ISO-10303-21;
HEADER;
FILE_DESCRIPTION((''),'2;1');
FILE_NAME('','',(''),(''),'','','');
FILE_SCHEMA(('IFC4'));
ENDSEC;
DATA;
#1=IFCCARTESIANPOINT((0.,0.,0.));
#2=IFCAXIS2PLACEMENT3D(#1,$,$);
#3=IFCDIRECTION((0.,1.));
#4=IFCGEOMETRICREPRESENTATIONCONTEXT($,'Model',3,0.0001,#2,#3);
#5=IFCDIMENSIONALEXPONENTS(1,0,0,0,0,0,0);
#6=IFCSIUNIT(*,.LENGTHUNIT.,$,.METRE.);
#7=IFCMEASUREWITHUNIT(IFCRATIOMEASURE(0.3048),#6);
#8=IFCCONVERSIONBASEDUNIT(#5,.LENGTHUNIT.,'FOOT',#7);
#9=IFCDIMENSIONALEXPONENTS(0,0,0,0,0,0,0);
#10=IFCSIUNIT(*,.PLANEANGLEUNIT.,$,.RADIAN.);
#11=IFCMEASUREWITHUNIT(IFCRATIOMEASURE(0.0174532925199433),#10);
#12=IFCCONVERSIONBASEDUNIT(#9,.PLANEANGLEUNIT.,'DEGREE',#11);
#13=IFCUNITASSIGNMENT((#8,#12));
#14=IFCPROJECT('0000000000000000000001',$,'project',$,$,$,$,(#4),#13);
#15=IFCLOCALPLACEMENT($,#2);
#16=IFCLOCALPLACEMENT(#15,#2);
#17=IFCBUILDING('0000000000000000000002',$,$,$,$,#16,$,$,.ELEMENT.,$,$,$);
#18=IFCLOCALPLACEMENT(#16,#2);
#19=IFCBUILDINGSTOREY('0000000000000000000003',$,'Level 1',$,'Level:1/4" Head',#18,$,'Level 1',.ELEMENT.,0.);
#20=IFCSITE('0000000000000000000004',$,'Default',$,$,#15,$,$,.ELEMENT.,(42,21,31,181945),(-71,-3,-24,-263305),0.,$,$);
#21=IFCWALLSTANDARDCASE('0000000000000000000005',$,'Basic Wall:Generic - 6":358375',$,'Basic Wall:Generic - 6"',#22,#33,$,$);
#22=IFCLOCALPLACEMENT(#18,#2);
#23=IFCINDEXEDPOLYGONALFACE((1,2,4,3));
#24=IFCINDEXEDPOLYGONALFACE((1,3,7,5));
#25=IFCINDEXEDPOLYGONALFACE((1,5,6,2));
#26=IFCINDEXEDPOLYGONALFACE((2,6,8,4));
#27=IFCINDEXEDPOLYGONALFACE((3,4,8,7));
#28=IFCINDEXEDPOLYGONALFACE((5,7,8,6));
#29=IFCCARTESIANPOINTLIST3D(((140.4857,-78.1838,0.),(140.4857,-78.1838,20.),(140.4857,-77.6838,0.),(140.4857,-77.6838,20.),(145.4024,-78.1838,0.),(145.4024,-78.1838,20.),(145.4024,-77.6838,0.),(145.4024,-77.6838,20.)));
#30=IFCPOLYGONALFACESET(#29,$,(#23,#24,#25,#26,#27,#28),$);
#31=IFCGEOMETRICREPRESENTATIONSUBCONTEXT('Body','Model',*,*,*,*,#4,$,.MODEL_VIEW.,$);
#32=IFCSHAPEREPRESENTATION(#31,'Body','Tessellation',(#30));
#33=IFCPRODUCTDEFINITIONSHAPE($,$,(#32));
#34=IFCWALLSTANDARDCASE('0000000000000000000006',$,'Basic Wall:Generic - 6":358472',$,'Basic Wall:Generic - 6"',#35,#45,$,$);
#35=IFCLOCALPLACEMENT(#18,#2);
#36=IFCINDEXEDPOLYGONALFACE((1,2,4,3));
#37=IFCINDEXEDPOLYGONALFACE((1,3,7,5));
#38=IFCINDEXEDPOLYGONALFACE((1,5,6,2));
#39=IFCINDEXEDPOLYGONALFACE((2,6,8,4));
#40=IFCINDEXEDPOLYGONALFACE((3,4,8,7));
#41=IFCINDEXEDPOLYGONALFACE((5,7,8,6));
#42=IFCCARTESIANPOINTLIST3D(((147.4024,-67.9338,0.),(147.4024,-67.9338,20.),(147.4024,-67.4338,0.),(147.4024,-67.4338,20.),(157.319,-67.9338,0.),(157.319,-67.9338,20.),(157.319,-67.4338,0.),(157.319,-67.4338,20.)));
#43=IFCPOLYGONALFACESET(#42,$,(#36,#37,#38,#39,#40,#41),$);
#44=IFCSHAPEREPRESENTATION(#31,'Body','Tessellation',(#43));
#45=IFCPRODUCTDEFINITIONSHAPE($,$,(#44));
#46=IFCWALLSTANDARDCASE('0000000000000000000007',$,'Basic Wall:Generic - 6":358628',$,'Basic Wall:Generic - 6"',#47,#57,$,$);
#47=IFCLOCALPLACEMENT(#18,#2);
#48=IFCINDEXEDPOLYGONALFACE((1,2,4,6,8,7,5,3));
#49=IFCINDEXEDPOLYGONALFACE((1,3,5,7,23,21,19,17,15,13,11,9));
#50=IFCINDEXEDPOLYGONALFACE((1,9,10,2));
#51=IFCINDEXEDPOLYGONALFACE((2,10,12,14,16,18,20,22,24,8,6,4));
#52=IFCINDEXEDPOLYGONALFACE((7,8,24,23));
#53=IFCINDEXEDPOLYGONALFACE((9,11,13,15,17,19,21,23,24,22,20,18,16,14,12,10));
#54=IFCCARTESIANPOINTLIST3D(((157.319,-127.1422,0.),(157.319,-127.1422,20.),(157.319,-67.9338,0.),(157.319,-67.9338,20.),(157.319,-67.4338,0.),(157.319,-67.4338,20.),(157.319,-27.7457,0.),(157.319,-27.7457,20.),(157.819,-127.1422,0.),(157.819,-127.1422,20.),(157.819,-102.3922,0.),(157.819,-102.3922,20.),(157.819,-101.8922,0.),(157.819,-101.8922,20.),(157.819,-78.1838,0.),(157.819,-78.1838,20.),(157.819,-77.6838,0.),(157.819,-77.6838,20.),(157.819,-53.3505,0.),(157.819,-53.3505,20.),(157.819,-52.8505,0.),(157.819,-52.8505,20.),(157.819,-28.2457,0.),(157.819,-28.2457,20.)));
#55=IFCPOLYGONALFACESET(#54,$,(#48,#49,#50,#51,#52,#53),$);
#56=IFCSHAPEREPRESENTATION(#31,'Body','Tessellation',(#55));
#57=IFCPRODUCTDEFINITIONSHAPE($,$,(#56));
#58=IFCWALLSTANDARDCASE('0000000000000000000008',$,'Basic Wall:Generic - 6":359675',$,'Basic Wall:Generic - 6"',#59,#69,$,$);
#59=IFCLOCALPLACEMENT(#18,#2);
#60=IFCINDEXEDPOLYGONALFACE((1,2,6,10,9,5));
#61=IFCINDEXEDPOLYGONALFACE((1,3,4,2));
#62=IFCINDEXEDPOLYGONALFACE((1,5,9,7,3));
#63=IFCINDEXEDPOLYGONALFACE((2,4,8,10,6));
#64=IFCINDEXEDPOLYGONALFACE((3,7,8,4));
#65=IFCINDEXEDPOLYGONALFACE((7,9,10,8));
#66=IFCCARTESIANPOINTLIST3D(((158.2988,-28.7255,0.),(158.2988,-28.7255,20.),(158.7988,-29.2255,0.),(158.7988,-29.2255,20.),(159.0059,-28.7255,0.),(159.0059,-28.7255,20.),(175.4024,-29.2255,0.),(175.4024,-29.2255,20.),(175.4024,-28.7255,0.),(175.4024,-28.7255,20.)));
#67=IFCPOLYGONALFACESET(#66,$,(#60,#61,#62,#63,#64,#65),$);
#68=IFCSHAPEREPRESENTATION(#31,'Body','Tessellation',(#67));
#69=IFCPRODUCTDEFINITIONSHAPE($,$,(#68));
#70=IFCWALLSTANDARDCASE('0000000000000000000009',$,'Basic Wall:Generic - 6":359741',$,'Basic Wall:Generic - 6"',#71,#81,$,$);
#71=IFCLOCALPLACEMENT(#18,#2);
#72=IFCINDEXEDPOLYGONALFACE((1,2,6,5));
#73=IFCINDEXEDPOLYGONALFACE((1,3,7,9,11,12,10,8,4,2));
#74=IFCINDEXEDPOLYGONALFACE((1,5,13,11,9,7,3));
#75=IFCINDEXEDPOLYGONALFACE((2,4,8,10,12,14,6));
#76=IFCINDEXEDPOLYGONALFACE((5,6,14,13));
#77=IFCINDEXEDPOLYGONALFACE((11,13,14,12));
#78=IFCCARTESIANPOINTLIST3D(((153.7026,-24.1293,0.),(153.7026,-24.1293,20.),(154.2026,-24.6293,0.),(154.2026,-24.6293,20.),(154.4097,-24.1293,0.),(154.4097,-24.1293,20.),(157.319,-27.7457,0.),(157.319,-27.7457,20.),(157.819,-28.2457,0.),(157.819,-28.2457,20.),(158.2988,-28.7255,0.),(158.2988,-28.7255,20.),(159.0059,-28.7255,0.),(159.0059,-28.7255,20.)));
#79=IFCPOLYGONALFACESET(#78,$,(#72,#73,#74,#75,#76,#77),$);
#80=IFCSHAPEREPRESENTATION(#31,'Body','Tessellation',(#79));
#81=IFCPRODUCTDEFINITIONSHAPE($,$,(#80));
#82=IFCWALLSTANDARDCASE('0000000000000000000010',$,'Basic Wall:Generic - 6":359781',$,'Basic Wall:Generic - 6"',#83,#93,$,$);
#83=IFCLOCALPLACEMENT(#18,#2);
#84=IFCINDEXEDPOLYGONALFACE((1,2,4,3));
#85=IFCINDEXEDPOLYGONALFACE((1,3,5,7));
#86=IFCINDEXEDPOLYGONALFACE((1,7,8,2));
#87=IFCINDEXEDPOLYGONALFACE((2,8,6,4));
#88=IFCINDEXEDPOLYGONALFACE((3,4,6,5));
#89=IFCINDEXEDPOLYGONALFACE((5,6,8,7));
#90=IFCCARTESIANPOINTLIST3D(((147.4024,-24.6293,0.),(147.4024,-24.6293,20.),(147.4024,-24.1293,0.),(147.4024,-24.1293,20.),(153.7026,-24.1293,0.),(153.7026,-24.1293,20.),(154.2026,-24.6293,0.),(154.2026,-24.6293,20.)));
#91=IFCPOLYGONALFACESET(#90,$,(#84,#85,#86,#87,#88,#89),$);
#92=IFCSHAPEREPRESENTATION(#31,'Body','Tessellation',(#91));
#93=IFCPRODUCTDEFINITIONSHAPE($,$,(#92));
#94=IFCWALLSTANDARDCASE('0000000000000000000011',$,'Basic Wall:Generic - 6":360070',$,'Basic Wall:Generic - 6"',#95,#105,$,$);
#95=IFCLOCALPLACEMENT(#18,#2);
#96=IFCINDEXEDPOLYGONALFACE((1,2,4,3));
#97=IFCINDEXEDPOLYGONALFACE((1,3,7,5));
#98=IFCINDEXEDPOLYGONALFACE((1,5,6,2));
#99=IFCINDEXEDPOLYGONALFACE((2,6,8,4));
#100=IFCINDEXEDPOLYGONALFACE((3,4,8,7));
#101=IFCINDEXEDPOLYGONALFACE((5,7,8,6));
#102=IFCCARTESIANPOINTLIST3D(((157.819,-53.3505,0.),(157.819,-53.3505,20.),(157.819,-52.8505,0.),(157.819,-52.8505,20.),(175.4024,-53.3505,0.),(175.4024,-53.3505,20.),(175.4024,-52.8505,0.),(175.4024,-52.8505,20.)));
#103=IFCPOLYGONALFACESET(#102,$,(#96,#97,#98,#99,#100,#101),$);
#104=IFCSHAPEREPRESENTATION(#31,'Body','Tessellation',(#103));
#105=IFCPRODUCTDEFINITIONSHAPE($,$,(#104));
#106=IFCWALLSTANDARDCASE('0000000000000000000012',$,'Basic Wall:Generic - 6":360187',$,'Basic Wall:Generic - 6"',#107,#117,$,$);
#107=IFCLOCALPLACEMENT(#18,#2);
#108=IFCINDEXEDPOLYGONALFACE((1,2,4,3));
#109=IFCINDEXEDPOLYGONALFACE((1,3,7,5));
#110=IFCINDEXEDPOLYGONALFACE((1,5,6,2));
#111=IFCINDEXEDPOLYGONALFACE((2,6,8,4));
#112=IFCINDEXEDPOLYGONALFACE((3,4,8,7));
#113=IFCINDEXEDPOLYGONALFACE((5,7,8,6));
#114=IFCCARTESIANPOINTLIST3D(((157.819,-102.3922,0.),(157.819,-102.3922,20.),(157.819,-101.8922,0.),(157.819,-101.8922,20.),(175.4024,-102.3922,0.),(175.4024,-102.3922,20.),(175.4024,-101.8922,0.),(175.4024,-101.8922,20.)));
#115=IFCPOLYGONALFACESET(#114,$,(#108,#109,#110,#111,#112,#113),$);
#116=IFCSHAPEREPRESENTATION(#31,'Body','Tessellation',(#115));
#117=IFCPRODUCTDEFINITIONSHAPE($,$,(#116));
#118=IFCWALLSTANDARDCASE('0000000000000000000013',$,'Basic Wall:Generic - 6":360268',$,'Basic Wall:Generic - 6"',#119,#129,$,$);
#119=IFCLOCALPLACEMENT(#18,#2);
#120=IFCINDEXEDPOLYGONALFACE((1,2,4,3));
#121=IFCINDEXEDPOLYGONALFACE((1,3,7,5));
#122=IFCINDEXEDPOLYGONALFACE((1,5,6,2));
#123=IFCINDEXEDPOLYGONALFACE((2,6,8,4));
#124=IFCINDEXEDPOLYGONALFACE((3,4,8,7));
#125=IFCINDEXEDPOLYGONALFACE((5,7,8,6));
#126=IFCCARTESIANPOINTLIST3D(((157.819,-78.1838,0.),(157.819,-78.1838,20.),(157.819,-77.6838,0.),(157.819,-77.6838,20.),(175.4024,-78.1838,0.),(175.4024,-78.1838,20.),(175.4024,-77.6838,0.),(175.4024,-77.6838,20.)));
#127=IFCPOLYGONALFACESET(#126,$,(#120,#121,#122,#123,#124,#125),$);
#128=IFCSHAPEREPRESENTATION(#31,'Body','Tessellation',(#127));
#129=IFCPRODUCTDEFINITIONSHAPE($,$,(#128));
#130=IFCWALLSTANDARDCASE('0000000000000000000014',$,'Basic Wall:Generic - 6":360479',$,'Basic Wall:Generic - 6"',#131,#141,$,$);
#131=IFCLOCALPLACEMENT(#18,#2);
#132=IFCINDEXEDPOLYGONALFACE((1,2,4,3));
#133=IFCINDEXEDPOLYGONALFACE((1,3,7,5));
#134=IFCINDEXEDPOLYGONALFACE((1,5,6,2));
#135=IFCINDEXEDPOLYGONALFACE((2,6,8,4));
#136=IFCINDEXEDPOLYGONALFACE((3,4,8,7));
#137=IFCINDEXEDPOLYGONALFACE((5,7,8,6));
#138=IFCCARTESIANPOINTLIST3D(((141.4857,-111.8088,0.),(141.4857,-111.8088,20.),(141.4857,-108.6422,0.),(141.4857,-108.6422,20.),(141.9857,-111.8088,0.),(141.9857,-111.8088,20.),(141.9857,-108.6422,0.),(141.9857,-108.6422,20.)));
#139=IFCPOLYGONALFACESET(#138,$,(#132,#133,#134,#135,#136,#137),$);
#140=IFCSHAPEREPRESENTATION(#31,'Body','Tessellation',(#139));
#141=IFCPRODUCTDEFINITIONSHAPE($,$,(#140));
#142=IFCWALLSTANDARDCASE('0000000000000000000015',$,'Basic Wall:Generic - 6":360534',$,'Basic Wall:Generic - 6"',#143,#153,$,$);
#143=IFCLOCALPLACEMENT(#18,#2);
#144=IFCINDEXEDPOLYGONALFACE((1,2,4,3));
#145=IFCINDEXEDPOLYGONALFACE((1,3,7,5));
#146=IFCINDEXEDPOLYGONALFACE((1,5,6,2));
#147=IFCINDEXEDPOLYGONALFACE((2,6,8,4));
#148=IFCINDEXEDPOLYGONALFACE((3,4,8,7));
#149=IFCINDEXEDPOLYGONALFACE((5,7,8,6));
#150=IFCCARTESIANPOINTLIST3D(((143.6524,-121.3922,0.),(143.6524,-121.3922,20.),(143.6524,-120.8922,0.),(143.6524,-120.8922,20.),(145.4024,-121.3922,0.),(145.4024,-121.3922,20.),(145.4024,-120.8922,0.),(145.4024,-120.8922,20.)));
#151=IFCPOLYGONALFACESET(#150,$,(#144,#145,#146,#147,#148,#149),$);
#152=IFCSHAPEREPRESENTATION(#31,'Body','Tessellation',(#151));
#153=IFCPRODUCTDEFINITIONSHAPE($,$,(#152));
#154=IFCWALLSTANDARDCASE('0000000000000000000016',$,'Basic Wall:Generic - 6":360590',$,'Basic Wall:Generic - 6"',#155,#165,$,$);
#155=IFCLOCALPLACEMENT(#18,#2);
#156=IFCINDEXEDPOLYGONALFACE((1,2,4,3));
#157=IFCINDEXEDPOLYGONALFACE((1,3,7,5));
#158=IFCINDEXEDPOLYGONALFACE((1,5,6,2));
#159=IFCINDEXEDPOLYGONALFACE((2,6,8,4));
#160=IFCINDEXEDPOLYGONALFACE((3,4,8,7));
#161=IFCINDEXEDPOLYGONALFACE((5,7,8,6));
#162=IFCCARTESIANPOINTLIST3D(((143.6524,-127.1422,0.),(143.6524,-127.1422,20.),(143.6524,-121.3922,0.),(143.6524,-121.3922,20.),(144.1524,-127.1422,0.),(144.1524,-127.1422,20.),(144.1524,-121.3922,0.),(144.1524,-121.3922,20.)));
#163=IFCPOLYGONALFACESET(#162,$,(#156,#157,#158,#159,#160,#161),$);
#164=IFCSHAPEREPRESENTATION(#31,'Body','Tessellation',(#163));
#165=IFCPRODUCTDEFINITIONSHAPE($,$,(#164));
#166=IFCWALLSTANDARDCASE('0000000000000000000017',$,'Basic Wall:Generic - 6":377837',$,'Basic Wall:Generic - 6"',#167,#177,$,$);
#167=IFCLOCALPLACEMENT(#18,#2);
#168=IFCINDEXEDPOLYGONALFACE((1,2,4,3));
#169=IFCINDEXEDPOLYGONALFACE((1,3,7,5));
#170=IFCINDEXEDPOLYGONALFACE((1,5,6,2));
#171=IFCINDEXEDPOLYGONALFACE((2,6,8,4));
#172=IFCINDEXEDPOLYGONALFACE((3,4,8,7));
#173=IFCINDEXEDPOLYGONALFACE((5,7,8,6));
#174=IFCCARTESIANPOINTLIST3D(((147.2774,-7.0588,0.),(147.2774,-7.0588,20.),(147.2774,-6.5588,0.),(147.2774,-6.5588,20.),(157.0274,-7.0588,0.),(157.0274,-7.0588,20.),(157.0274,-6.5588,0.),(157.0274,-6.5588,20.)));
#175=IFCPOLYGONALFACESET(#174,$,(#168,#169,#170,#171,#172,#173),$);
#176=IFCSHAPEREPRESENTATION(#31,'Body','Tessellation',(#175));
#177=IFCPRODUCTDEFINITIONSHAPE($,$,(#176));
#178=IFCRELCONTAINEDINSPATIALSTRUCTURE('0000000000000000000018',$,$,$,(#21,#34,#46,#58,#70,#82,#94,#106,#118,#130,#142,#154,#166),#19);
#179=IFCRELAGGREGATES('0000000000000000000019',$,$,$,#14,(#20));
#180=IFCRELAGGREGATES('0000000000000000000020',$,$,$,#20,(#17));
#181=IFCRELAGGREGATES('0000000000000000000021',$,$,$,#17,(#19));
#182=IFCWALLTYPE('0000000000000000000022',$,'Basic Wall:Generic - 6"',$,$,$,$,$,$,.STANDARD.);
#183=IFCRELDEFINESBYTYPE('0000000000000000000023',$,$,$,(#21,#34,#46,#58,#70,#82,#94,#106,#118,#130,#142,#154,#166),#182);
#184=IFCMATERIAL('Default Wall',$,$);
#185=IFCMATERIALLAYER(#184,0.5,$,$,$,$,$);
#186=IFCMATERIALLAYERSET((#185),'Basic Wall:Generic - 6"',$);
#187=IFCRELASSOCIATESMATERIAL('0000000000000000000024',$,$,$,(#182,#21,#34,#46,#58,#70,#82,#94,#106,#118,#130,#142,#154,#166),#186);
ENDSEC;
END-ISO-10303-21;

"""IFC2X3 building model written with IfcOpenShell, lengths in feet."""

from ifc_helpers import new_model, entity, si_unit, converted_unit, direction, frame, frame_2d, origin, place, context, subcontext, project, spatial, polyline, rectangle, outline, extrude, material, layer, layer_set, layer_usage, type_object, element, save


model = new_model("IFC2X3")

# Units and contexts
model_context = context("Model", 3, precision=0.0001, world=origin(), true_north=direction((0.0, 1.0)))
body_context = subcontext(model_context, "Body", "Model", "MODEL_VIEW")
ifc_project = project(units=[converted_unit("LENGTHUNIT", "FOOT", entity("IfcRatioMeasure", 0.3048), si_unit("LENGTHUNIT", "METRE"), dimensions=[1, 0, 0, 0, 0, 0, 0]), converted_unit("PLANEANGLEUNIT", "DEGREE", entity("IfcRatioMeasure", 0.0174532925199433), si_unit("PLANEANGLEUNIT", "RADIAN"), dimensions=[0, 0, 0, 0, 0, 0, 0])], contexts=[model_context])

# Site, building, storey
site_placement = place(None, origin())
site = spatial("IfcSite", under=ifc_project, at=site_placement, Name="Default", CompositionType="ELEMENT", RefLatitude=(42, 21, 31, 181945), RefLongitude=(-71, -3, -24, -263305), RefElevation=0.0)
building_placement = place(site_placement, origin())
building = spatial("IfcBuilding", under=site, at=building_placement, CompositionType="ELEMENT")
storey_placement = place(building_placement, origin())
storey = spatial("IfcBuildingStorey", under=building, at=storey_placement, Name="Level 1", ObjectType="Level:1/4\" Head", LongName="Level 1", CompositionType="ELEMENT", Elevation=0.0)

# Walls
ifc_material = material(Name="Default Wall")
ifc_layer_1 = layer(ifc_material, 0.5)
ifc_layer_set_1 = layer_set([ifc_layer_1], Name="Basic Wall:Generic - 6\"")
wall_type_1 = type_object("IfcWallType", Name="Basic Wall:Generic - 6\"", PredefinedType="STANDARD", material=ifc_layer_set_1)
ifc_layer_usage_1 = layer_usage(ifc_layer_set_1, "AXIS2", "NEGATIVE", 0.25)
wall_1_placement = place(storey_placement, frame((140.4857, -77.9338, 0.0)))
element("IfcWallStandardCase", 1, at=wall_1_placement, inside=storey, type_object=wall_type_1, material=ifc_layer_usage_1, Name="Basic Wall:Generic - 6\":358375", ObjectType="Basic Wall:Generic - 6\"", context=body_context, shape_type="SweptSolid", body=[
    extrude(rectangle(XDim=4.9167, YDim=0.5, at=frame_2d((2.4583, 0.0), x_axis=(-1.0, 0.0))), origin(), (0.0, 0.0, 1.0), 20.0),
])
ifc_layer_usage_2 = layer_usage(ifc_layer_set_1, "AXIS2", "NEGATIVE", 0.25)
wall_2_placement = place(storey_placement, frame((147.4024, -67.6838, 0.0)))
element("IfcWallStandardCase", 2, at=wall_2_placement, inside=storey, type_object=wall_type_1, material=ifc_layer_usage_2, Name="Basic Wall:Generic - 6\":358472", ObjectType="Basic Wall:Generic - 6\"", context=body_context, shape_type="SweptSolid", body=[
    extrude(rectangle(XDim=9.9167, YDim=0.5, at=frame_2d((4.9583, 0.0), x_axis=(-1.0, 0.0))), origin(), (0.0, 0.0, 1.0), 20.0),
])
ifc_layer_usage_3 = layer_usage(ifc_layer_set_1, "AXIS2", "NEGATIVE", 0.25)
wall_3_placement = place(storey_placement, frame((157.569, -27.7457, 0.0), z_axis=(0.0, 0.0, 1.0), x_axis=(0.0, -1.0, 0.0)))
element("IfcWallStandardCase", 3, at=wall_3_placement, inside=storey, type_object=wall_type_1, material=ifc_layer_usage_3, Name="Basic Wall:Generic - 6\":358628", ObjectType="Basic Wall:Generic - 6\"", context=body_context, shape_type="SweptSolid", body=[
    extrude(outline(polyline([(99.3964, -0.25), (99.3964, 0.25), (74.6464, 0.25), (74.1464, 0.25), (50.4381, 0.25), (49.9381, 0.25), (25.6048, 0.25), (25.1048, 0.25), (0.5, 0.25), (0.0, -0.25), (39.6881, -0.25), (40.1881, -0.25), (99.3964, -0.25)])), origin(), (0.0, 0.0, 1.0), 20.0),
])
ifc_layer_usage_4 = layer_usage(ifc_layer_set_1, "AXIS2", "NEGATIVE", 0.25)
wall_4_placement = place(storey_placement, frame((175.4024, -28.9755, 0.0), z_axis=(0.0, 0.0, 1.0), x_axis=(-1.0, 0.0, 0.0)))
element("IfcWallStandardCase", 4, at=wall_4_placement, inside=storey, type_object=wall_type_1, material=ifc_layer_usage_4, Name="Basic Wall:Generic - 6\":359675", ObjectType="Basic Wall:Generic - 6\"", context=body_context, shape_type="SweptSolid", body=[
    extrude(outline(polyline([(17.1036, -0.25), (16.6036, 0.25), (0.0, 0.25), (0.0, -0.25), (16.3964, -0.25), (17.1036, -0.25)])), origin(), (0.0, 0.0, 1.0), 20.0),
])
ifc_layer_usage_5 = layer_usage(ifc_layer_set_1, "AXIS2", "NEGATIVE", 0.25)
wall_5_placement = place(storey_placement, frame((158.8291, -28.9023, 0.0), z_axis=(0.0, 0.0, 1.0), x_axis=(-0.707107, 0.707107, 0.0)))
element("IfcWallStandardCase", 5, at=wall_5_placement, inside=storey, type_object=wall_type_1, material=ifc_layer_usage_5, Name="Basic Wall:Generic - 6\":359741", ObjectType="Basic Wall:Generic - 6\"", context=body_context, shape_type="SweptSolid", body=[
    extrude(outline(polyline([(6.5, -0.25), (7.0, 0.25), (6.2929, 0.25), (1.8856, 0.25), (1.1785, 0.25), (0.5, 0.25), (0.0, -0.25), (6.5, -0.25)])), origin(), (0.0, 0.0, 1.0), 20.0),
])
ifc_layer_usage_6 = layer_usage(ifc_layer_set_1, "AXIS2", "NEGATIVE", 0.25)
wall_6_placement = place(storey_placement, frame((154.2026, -24.3793, 0.0), z_axis=(0.0, 0.0, 1.0), x_axis=(-1.0, 0.0, 0.0)))
element("IfcWallStandardCase", 6, at=wall_6_placement, inside=storey, type_object=wall_type_1, material=ifc_layer_usage_6, Name="Basic Wall:Generic - 6\":359781", ObjectType="Basic Wall:Generic - 6\"", context=body_context, shape_type="SweptSolid", body=[
    extrude(outline(polyline([(6.8003, -0.25), (6.8003, 0.25), (0.0, 0.25), (0.5, -0.25), (6.8003, -0.25)])), origin(), (0.0, 0.0, 1.0), 20.0),
])
ifc_layer_usage_7 = layer_usage(ifc_layer_set_1, "AXIS2", "NEGATIVE", 0.25)
wall_7_placement = place(storey_placement, frame((157.819, -53.1005, 0.0)))
element("IfcWallStandardCase", 7, at=wall_7_placement, inside=storey, type_object=wall_type_1, material=ifc_layer_usage_7, Name="Basic Wall:Generic - 6\":360070", ObjectType="Basic Wall:Generic - 6\"", context=body_context, shape_type="SweptSolid", body=[
    extrude(rectangle(XDim=17.5833, YDim=0.5, at=frame_2d((8.7917, 0.0), x_axis=(-1.0, 0.0))), origin(), (0.0, 0.0, 1.0), 20.0),
])
ifc_layer_usage_8 = layer_usage(ifc_layer_set_1, "AXIS2", "NEGATIVE", 0.25)
wall_8_placement = place(storey_placement, frame((175.4024, -102.1422, 0.0), z_axis=(0.0, 0.0, 1.0), x_axis=(-1.0, 0.0, 0.0)))
element("IfcWallStandardCase", 8, at=wall_8_placement, inside=storey, type_object=wall_type_1, material=ifc_layer_usage_8, Name="Basic Wall:Generic - 6\":360187", ObjectType="Basic Wall:Generic - 6\"", context=body_context, shape_type="SweptSolid", body=[
    extrude(rectangle(XDim=17.5833, YDim=0.5, at=frame_2d((8.7917, 0.0), x_axis=(-1.0, 0.0))), origin(), (0.0, 0.0, 1.0), 20.0),
])
ifc_layer_usage_9 = layer_usage(ifc_layer_set_1, "AXIS2", "NEGATIVE", 0.25)
wall_9_placement = place(storey_placement, frame((175.4024, -77.9338, 0.0), z_axis=(0.0, 0.0, 1.0), x_axis=(-1.0, 0.0, 0.0)))
element("IfcWallStandardCase", 9, at=wall_9_placement, inside=storey, type_object=wall_type_1, material=ifc_layer_usage_9, Name="Basic Wall:Generic - 6\":360268", ObjectType="Basic Wall:Generic - 6\"", context=body_context, shape_type="SweptSolid", body=[
    extrude(rectangle(XDim=17.5833, YDim=0.5, at=frame_2d((8.7917, 0.0), x_axis=(-1.0, 0.0))), origin(), (0.0, 0.0, 1.0), 20.0),
])
ifc_layer_usage_10 = layer_usage(ifc_layer_set_1, "AXIS2", "NEGATIVE", 0.25)
wall_10_placement = place(storey_placement, frame((141.7357, -111.8088, 0.0), z_axis=(0.0, 0.0, 1.0), x_axis=(0.0, 1.0, 0.0)))
element("IfcWallStandardCase", 10, at=wall_10_placement, inside=storey, type_object=wall_type_1, material=ifc_layer_usage_10, Name="Basic Wall:Generic - 6\":360479", ObjectType="Basic Wall:Generic - 6\"", context=body_context, shape_type="SweptSolid", body=[
    extrude(rectangle(XDim=3.1667, YDim=0.5, at=frame_2d((1.5833, 0.0), x_axis=(-1.0, 0.0))), origin(), (0.0, 0.0, 1.0), 20.0),
])
ifc_layer_usage_11 = layer_usage(ifc_layer_set_1, "AXIS2", "NEGATIVE", 0.25)
wall_11_placement = place(storey_placement, frame((145.4024, -121.1422, 0.0), z_axis=(0.0, 0.0, 1.0), x_axis=(-1.0, 0.0, 0.0)))
element("IfcWallStandardCase", 11, at=wall_11_placement, inside=storey, type_object=wall_type_1, material=ifc_layer_usage_11, Name="Basic Wall:Generic - 6\":360534", ObjectType="Basic Wall:Generic - 6\"", context=body_context, shape_type="SweptSolid", body=[
    extrude(rectangle(XDim=1.75, YDim=0.5, at=frame_2d((0.875, 0.0), x_axis=(-1.0, 0.0))), origin(), (0.0, 0.0, 1.0), 20.0),
])
ifc_layer_usage_12 = layer_usage(ifc_layer_set_1, "AXIS2", "NEGATIVE", 0.25)
wall_12_placement = place(storey_placement, frame((143.9024, -121.3922, 0.0), z_axis=(0.0, 0.0, 1.0), x_axis=(0.0, -1.0, 0.0)))
element("IfcWallStandardCase", 12, at=wall_12_placement, inside=storey, type_object=wall_type_1, material=ifc_layer_usage_12, Name="Basic Wall:Generic - 6\":360590", ObjectType="Basic Wall:Generic - 6\"", context=body_context, shape_type="SweptSolid", body=[
    extrude(rectangle(XDim=5.75, YDim=0.5, at=frame_2d((2.875, 0.0), x_axis=(-1.0, 0.0))), origin(), (0.0, 0.0, 1.0), 20.0),
])
ifc_layer_usage_13 = layer_usage(ifc_layer_set_1, "AXIS2", "NEGATIVE", 0.25)
wall_13_placement = place(storey_placement, frame((147.2774, -6.8088, 0.0)))
element("IfcWallStandardCase", 13, at=wall_13_placement, inside=storey, type_object=wall_type_1, material=ifc_layer_usage_13, Name="Basic Wall:Generic - 6\":377837", ObjectType="Basic Wall:Generic - 6\"", context=body_context, shape_type="SweptSolid", body=[
    extrude(rectangle(XDim=9.75, YDim=0.5, at=frame_2d((4.875, 0.0), x_axis=(-1.0, 0.0))), origin(), (0.0, 0.0, 1.0), 20.0),
])

save(model, "model.ifc")
